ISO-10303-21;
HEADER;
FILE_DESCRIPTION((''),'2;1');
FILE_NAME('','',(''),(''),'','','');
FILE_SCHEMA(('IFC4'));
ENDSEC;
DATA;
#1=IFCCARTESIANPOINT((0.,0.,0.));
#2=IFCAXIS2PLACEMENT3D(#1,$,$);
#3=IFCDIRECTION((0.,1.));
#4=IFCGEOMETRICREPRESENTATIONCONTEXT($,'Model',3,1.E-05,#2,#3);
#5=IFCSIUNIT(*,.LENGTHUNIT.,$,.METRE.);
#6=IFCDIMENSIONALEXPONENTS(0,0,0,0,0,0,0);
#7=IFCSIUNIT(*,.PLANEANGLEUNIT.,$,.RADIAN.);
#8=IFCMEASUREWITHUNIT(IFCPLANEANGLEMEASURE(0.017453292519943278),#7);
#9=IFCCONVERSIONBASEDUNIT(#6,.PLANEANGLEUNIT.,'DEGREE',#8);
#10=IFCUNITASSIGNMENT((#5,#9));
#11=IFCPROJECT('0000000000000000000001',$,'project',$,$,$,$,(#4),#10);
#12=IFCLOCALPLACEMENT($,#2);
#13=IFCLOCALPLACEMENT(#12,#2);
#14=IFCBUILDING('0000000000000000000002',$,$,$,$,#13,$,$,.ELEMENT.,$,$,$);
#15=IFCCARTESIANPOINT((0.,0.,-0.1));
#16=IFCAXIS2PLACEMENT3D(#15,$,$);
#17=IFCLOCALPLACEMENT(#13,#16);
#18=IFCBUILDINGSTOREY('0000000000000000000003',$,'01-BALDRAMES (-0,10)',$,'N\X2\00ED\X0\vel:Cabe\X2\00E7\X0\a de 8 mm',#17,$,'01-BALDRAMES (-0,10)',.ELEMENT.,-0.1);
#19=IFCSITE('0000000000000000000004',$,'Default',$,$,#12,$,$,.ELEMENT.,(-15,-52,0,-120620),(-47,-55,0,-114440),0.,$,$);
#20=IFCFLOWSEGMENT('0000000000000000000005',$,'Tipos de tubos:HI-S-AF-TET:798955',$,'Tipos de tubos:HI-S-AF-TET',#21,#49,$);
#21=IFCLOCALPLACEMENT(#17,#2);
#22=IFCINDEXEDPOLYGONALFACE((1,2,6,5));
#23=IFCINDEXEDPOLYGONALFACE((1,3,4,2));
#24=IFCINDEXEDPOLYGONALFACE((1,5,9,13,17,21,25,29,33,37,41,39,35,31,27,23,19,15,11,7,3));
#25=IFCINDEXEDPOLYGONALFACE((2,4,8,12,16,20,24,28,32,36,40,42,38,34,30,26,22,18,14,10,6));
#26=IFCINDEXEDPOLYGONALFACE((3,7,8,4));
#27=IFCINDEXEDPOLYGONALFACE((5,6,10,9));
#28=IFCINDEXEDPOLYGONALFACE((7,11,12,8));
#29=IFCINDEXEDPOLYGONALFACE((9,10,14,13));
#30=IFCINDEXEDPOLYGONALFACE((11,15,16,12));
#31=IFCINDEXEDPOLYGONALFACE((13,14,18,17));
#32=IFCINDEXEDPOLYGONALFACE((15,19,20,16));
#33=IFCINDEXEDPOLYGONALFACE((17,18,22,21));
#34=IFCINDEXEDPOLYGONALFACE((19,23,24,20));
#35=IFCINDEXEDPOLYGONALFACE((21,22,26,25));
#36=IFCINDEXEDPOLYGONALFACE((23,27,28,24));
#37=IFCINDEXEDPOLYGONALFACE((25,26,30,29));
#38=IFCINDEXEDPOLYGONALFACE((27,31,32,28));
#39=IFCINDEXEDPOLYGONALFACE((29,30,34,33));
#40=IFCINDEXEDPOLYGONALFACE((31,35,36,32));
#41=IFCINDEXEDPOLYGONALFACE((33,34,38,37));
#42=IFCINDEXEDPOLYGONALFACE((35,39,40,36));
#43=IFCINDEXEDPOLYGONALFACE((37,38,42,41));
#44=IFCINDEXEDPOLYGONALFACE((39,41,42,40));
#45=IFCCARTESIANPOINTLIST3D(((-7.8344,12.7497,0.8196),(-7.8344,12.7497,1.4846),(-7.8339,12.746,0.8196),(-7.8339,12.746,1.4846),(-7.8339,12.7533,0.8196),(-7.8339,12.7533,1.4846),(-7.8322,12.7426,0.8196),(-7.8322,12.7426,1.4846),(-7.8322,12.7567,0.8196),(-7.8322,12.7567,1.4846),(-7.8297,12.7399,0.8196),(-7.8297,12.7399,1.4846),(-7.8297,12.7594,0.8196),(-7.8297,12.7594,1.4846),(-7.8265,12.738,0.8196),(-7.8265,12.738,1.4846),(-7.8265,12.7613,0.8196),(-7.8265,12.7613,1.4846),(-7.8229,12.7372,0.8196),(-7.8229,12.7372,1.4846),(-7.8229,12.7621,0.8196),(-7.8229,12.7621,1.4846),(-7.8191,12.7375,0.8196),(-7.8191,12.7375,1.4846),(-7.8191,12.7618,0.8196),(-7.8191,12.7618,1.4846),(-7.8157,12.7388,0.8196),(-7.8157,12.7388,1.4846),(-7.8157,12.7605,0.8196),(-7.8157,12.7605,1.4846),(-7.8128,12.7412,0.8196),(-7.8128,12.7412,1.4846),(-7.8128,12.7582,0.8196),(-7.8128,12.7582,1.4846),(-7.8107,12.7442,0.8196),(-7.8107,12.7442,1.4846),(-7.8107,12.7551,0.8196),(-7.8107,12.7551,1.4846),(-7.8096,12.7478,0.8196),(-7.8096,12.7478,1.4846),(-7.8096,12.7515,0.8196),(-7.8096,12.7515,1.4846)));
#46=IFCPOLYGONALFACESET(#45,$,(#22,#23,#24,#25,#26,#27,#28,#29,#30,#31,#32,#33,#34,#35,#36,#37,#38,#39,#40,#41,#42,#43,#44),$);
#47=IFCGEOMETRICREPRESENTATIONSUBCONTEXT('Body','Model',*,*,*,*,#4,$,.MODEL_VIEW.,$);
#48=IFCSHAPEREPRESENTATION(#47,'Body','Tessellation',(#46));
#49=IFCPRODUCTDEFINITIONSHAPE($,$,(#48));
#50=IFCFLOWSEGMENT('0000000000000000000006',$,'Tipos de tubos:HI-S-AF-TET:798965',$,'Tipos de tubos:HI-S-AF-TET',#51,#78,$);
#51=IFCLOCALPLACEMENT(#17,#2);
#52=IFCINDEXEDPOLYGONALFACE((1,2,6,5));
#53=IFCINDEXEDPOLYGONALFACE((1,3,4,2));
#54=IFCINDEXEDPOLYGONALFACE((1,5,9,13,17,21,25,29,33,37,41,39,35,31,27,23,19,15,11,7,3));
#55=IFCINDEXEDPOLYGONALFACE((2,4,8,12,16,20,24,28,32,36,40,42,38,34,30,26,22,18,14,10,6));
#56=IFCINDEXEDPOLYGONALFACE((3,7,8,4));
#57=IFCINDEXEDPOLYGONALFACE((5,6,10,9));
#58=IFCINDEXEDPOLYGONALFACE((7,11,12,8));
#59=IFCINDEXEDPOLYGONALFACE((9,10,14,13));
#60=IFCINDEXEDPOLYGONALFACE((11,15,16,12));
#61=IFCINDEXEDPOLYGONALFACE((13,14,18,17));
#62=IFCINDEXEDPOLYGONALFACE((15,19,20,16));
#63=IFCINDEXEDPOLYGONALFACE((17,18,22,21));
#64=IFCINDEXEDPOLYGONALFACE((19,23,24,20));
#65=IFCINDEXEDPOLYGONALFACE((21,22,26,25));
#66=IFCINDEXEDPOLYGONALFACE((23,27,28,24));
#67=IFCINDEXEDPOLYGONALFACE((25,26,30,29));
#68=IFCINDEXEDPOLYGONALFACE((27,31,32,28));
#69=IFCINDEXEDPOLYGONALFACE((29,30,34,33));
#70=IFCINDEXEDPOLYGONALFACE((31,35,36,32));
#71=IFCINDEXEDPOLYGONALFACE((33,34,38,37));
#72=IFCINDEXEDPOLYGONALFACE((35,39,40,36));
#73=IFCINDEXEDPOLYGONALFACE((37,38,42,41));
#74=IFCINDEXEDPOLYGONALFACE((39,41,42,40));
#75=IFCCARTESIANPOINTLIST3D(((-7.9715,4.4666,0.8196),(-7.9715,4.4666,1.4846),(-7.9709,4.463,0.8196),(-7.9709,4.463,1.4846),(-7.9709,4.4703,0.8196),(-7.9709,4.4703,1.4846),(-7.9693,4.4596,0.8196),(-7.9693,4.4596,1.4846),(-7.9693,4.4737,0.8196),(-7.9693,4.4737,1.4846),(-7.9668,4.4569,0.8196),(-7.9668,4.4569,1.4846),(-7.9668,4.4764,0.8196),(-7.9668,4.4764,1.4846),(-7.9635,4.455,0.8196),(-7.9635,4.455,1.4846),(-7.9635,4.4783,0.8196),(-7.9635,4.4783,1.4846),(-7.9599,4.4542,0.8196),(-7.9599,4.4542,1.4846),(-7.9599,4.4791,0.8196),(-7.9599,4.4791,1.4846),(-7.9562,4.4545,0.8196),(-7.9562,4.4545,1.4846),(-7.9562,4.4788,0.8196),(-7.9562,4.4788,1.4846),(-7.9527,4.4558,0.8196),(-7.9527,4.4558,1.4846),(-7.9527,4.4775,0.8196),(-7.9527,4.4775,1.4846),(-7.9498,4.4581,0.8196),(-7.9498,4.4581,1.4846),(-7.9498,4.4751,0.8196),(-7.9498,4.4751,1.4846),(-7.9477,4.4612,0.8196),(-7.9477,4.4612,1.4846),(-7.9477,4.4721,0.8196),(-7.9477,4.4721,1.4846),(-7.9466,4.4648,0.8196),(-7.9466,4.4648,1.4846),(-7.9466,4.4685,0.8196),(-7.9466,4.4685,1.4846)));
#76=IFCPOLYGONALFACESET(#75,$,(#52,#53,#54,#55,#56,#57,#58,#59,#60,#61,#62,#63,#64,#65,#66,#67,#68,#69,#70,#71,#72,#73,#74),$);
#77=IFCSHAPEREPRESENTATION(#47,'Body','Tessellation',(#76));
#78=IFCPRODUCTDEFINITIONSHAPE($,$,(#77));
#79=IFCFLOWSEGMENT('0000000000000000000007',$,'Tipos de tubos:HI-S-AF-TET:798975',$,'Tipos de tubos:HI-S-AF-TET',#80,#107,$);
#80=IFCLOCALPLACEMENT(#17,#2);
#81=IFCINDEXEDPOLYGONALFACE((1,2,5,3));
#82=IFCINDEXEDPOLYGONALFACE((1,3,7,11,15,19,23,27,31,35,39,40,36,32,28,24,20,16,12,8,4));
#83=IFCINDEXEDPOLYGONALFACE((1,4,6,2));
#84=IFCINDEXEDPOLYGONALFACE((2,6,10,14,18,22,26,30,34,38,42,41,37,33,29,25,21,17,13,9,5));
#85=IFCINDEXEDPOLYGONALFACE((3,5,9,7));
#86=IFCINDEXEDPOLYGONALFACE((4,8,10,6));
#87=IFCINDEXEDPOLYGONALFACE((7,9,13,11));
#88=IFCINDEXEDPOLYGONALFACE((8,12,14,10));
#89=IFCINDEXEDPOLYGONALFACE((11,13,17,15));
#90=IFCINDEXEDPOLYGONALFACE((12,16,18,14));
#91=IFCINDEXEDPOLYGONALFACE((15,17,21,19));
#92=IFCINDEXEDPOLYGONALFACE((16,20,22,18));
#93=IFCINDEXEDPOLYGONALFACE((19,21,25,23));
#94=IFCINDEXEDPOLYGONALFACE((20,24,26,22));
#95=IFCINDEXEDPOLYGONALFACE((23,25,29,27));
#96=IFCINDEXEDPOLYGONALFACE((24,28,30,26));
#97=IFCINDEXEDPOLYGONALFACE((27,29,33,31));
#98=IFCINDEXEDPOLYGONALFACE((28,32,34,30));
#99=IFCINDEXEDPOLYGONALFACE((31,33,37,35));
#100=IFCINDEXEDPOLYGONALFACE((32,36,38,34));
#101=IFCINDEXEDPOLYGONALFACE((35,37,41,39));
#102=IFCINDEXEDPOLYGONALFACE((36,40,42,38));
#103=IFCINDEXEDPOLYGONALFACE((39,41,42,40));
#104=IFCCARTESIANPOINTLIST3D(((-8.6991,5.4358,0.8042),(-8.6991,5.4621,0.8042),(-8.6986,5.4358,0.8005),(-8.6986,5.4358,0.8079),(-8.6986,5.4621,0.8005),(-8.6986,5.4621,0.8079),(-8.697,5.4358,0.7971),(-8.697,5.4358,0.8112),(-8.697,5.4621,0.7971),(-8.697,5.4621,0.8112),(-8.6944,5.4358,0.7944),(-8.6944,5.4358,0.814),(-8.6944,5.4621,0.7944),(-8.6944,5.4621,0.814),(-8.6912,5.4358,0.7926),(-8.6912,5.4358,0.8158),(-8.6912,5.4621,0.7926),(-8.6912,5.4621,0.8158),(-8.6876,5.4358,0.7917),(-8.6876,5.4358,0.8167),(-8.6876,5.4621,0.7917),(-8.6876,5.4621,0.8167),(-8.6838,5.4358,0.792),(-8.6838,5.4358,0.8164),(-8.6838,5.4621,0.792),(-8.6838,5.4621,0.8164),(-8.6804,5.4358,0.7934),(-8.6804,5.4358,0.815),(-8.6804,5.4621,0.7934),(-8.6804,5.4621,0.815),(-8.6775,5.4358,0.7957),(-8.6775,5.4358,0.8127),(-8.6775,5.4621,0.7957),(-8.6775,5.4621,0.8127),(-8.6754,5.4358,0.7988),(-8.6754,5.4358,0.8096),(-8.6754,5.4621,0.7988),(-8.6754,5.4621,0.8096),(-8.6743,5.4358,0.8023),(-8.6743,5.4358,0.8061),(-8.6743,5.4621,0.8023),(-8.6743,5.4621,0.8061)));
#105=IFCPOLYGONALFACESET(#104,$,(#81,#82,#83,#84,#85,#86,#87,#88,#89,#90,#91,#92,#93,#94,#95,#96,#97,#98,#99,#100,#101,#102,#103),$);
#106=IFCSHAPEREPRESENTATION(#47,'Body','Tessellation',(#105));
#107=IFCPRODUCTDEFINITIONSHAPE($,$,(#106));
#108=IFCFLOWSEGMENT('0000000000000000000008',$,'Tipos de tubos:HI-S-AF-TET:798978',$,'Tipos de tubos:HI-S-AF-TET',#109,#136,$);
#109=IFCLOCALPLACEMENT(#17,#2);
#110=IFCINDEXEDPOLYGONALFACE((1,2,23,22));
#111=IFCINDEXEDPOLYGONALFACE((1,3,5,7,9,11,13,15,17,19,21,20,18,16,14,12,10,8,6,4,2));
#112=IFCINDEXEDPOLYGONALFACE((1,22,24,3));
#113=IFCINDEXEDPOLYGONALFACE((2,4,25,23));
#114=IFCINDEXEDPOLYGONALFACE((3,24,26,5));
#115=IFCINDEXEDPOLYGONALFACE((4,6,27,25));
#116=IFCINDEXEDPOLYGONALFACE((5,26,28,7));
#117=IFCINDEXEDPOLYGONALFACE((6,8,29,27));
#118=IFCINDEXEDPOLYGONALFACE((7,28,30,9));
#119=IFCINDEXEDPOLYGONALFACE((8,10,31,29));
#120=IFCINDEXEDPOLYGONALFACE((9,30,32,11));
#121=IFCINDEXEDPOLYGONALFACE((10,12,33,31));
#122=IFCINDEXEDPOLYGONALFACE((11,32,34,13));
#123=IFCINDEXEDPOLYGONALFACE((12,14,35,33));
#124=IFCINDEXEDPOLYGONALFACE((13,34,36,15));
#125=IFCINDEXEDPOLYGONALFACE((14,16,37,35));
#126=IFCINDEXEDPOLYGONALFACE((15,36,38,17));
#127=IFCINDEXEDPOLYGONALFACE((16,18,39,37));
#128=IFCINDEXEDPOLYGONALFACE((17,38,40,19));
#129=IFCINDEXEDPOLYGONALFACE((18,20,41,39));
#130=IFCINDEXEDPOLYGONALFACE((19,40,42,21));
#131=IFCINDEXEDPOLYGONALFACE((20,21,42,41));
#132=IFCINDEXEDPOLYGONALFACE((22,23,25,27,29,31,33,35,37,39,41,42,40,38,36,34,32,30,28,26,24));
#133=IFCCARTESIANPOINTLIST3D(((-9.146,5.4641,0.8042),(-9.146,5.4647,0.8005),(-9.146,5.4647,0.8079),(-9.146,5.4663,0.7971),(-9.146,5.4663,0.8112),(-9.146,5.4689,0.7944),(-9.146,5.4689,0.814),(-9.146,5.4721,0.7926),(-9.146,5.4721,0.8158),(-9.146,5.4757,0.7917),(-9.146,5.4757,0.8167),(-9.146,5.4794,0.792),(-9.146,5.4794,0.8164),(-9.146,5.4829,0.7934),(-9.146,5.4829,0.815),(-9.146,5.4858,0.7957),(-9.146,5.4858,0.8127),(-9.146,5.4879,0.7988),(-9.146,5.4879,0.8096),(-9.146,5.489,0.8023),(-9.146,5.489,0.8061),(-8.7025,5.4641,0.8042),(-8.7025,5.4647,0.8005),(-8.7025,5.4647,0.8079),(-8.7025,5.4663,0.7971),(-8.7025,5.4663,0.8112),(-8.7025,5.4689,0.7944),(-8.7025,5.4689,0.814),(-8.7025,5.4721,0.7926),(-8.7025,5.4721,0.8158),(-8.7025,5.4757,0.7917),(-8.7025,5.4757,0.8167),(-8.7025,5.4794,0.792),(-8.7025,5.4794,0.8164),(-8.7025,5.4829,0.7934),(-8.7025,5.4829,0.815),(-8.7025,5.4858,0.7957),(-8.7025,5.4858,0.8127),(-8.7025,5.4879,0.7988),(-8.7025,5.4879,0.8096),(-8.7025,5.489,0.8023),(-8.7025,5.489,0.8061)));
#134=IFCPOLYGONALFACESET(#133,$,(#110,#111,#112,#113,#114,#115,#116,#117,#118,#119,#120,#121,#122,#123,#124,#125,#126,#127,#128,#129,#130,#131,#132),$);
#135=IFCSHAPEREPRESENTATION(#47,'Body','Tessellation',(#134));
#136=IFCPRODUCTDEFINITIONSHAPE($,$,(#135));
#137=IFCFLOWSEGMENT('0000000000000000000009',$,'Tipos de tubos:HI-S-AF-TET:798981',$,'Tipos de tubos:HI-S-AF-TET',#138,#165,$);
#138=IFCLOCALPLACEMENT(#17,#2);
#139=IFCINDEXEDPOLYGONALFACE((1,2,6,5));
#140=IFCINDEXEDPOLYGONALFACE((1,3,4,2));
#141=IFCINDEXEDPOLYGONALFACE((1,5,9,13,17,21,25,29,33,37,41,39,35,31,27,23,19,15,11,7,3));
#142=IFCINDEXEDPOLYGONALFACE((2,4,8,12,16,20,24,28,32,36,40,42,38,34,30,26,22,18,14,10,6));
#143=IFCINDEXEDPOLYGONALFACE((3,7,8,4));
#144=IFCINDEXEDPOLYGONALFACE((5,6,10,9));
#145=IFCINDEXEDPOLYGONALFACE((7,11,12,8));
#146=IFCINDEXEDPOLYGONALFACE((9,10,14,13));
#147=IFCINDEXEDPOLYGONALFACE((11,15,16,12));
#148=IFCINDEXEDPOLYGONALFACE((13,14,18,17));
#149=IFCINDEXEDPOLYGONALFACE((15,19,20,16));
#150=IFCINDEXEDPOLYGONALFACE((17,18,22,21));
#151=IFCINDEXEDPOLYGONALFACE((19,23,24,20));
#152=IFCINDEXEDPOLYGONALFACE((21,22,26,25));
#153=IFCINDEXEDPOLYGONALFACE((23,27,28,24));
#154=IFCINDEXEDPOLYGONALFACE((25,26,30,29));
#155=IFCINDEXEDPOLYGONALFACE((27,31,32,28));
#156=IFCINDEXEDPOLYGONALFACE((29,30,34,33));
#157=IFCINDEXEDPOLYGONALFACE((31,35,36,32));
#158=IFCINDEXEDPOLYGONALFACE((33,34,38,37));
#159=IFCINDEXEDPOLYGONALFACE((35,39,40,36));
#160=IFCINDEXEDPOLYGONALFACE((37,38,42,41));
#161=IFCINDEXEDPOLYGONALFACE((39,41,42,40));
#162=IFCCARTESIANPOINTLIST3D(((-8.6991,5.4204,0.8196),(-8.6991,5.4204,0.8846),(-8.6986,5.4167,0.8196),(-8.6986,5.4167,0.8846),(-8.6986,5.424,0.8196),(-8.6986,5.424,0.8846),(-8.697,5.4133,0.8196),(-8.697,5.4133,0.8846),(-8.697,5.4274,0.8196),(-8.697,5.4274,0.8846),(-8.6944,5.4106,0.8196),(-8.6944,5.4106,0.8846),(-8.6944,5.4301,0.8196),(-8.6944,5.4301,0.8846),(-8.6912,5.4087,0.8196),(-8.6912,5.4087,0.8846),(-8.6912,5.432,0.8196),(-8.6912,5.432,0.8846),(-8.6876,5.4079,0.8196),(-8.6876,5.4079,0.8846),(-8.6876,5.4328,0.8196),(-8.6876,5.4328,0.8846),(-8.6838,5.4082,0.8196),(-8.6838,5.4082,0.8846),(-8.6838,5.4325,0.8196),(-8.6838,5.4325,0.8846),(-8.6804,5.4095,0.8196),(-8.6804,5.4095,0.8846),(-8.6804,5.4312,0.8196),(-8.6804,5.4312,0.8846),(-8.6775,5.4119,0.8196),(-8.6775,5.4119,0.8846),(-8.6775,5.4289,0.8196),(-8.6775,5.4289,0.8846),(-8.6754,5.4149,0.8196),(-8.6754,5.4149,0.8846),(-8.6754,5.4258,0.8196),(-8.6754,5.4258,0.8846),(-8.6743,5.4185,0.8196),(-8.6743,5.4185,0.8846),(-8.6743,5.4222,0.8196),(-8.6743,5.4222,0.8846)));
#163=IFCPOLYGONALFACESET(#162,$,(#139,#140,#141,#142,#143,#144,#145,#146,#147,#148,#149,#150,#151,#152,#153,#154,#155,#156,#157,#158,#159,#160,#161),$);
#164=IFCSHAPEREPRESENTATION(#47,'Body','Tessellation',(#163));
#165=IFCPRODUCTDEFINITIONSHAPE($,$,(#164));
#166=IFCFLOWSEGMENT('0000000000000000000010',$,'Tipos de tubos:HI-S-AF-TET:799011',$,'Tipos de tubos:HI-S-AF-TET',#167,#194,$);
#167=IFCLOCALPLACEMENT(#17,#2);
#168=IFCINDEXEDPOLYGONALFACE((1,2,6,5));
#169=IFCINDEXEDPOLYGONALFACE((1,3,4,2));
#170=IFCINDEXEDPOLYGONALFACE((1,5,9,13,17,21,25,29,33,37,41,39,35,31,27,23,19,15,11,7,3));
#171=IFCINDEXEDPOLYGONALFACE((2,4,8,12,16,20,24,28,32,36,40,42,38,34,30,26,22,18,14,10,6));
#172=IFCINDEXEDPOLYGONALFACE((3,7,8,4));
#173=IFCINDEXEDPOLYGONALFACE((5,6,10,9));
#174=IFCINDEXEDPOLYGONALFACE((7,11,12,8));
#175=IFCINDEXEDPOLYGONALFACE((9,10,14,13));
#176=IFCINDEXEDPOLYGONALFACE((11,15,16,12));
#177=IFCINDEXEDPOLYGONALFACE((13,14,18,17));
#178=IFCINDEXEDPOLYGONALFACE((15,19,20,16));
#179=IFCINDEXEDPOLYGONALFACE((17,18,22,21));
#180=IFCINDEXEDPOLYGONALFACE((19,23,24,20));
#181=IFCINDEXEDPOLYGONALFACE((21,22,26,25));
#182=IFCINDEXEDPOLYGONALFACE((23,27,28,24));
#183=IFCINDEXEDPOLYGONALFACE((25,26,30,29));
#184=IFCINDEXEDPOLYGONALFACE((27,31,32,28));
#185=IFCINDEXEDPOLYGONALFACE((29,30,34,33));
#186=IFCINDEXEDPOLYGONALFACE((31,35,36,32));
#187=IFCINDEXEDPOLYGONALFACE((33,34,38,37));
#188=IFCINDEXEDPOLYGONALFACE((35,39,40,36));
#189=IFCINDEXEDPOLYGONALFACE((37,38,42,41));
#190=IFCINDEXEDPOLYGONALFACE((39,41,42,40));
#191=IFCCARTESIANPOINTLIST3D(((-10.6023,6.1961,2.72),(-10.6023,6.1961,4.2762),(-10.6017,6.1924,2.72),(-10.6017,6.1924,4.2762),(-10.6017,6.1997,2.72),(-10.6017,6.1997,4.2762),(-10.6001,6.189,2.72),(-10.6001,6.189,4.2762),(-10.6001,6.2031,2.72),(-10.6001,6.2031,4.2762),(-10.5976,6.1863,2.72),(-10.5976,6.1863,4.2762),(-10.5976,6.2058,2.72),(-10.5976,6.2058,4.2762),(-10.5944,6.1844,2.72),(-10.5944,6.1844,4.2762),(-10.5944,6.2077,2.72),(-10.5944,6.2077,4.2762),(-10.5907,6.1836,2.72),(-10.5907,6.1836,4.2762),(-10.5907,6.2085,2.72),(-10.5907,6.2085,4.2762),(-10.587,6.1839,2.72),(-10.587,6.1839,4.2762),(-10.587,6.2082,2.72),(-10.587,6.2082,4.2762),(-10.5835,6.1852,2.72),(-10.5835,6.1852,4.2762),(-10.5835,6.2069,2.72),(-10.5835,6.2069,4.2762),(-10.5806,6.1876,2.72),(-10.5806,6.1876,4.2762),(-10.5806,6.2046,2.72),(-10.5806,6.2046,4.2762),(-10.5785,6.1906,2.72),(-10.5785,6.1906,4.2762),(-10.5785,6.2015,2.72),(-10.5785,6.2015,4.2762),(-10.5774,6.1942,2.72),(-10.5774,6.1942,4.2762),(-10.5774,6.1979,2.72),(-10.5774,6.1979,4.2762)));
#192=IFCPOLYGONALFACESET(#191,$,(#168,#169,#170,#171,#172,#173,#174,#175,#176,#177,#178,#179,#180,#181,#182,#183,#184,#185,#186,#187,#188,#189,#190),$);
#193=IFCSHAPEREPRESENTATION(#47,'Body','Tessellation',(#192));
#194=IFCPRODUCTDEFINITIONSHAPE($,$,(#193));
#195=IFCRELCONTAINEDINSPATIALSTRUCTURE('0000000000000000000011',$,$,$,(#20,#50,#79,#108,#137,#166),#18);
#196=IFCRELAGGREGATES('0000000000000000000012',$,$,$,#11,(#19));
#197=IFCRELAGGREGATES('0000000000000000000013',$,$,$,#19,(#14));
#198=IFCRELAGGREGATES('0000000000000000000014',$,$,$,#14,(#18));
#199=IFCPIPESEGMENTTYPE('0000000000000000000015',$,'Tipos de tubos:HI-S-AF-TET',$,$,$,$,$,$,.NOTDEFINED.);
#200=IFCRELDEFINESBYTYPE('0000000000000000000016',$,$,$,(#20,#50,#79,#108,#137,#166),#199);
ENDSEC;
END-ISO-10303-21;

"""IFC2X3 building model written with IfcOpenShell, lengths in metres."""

from ifc_helpers import new_model, entity, si_unit, converted_unit, direction, frame, origin, origin_2d_with_axis, place, context, subcontext, project, spatial, circle, extrude, type_object, element, save


model = new_model("IFC2X3")

# Units and contexts
model_context = context("Model", 3, precision=1e-05, world=origin(), true_north=direction((0.0, 1.0)))
body_context = subcontext(model_context, "Body", "Model", "MODEL_VIEW")
ifc_project = project(units=[si_unit("LENGTHUNIT", "METRE"), converted_unit("PLANEANGLEUNIT", "DEGREE", entity("IfcPlaneAngleMeasure", 0.017453292519943278), si_unit("PLANEANGLEUNIT", "RADIAN"), dimensions=[0, 0, 0, 0, 0, 0, 0])], contexts=[model_context])

# Site, building, storey
site_placement = place(None, origin())
site = spatial("IfcSite", under=ifc_project, at=site_placement, Name="Default", CompositionType="ELEMENT", RefLatitude=(-15, -52, 0, -120620), RefLongitude=(-47, -55, 0, -114440), RefElevation=0.0)
building_placement = place(site_placement, origin())
building = spatial("IfcBuilding", under=site, at=building_placement, CompositionType="ELEMENT")
storey_placement = place(building_placement, frame((0.0, 0.0, -0.1)))
storey = spatial("IfcBuildingStorey", under=building, at=storey_placement, Name="01-BALDRAMES (-0,10)", ObjectType="Nível:Cabeça de 8 mm", LongName="01-BALDRAMES (-0,10)", CompositionType="ELEMENT", Elevation=-0.1)

# Flow segments
pipe_segment_type_1 = type_object("IfcPipeSegmentType", Name="Tipos de tubos:HI-S-AF-TET", PredefinedType="NOTDEFINED")
flow_segment_1_placement = place(storey_placement, origin())
element("IfcFlowSegment", 1, at=flow_segment_1_placement, inside=storey, type_object=pipe_segment_type_1, Name="Tipos de tubos:HI-S-AF-TET:798955", ObjectType="Tipos de tubos:HI-S-AF-TET", context=body_context, shape_type="SweptSolid", body=[
    extrude(circle(Radius=0.0125, at=origin_2d_with_axis()), frame((-7.8219, 12.7497, 0.8196), z_axis=(0.0, 0.0, 1.0), x_axis=(-1.0, 0.0, 0.0)), (0.0, 0.0, 1.0), 0.665),
])
flow_segment_2_placement = place(storey_placement, origin())
element("IfcFlowSegment", 2, at=flow_segment_2_placement, inside=storey, type_object=pipe_segment_type_1, Name="Tipos de tubos:HI-S-AF-TET:798965", ObjectType="Tipos de tubos:HI-S-AF-TET", context=body_context, shape_type="SweptSolid", body=[
    extrude(circle(Radius=0.0125, at=origin_2d_with_axis()), frame((-7.959, 4.4666, 0.8196), z_axis=(0.0, 0.0, 1.0), x_axis=(-1.0, 0.0, 0.0)), (0.0, 0.0, 1.0), 0.665),
])
flow_segment_3_placement = place(storey_placement, origin())
element("IfcFlowSegment", 3, at=flow_segment_3_placement, inside=storey, type_object=pipe_segment_type_1, Name="Tipos de tubos:HI-S-AF-TET:798975", ObjectType="Tipos de tubos:HI-S-AF-TET", context=body_context, shape_type="SweptSolid", body=[
    extrude(circle(Radius=0.0125, at=origin_2d_with_axis()), frame((-8.6866, 5.4358, 0.8042), z_axis=(0.0, 1.0, 0.0), x_axis=(-1.0, 0.0, 0.0)), (0.0, 0.0, 1.0), 0.0264),
])
flow_segment_4_placement = place(storey_placement, origin())
element("IfcFlowSegment", 4, at=flow_segment_4_placement, inside=storey, type_object=pipe_segment_type_1, Name="Tipos de tubos:HI-S-AF-TET:798978", ObjectType="Tipos de tubos:HI-S-AF-TET", context=body_context, shape_type="SweptSolid", body=[
    extrude(circle(Radius=0.0125, at=origin_2d_with_axis()), frame((-9.146, 5.4766, 0.8042), z_axis=(1.0, 0.0, 0.0), x_axis=(0.0, -1.0, 0.0)), (0.0, 0.0, 1.0), 0.4435),
])
flow_segment_5_placement = place(storey_placement, origin())
element("IfcFlowSegment", 5, at=flow_segment_5_placement, inside=storey, type_object=pipe_segment_type_1, Name="Tipos de tubos:HI-S-AF-TET:798981", ObjectType="Tipos de tubos:HI-S-AF-TET", context=body_context, shape_type="SweptSolid", body=[
    extrude(circle(Radius=0.0125, at=origin_2d_with_axis()), frame((-8.6866, 5.4204, 0.8196), z_axis=(0.0, 0.0, 1.0), x_axis=(-1.0, 0.0, 0.0)), (0.0, 0.0, 1.0), 0.065),
])
flow_segment_6_placement = place(storey_placement, origin())
element("IfcFlowSegment", 6, at=flow_segment_6_placement, inside=storey, type_object=pipe_segment_type_1, Name="Tipos de tubos:HI-S-AF-TET:799011", ObjectType="Tipos de tubos:HI-S-AF-TET", context=body_context, shape_type="SweptSolid", body=[
    extrude(circle(Radius=0.0125, at=origin_2d_with_axis()), frame((-10.5898, 6.1961, 2.72), z_axis=(0.0, 0.0, 1.0), x_axis=(-1.0, 0.0, 0.0)), (0.0, 0.0, 1.0), 1.5562),
])

save(model, "model.ifc")
